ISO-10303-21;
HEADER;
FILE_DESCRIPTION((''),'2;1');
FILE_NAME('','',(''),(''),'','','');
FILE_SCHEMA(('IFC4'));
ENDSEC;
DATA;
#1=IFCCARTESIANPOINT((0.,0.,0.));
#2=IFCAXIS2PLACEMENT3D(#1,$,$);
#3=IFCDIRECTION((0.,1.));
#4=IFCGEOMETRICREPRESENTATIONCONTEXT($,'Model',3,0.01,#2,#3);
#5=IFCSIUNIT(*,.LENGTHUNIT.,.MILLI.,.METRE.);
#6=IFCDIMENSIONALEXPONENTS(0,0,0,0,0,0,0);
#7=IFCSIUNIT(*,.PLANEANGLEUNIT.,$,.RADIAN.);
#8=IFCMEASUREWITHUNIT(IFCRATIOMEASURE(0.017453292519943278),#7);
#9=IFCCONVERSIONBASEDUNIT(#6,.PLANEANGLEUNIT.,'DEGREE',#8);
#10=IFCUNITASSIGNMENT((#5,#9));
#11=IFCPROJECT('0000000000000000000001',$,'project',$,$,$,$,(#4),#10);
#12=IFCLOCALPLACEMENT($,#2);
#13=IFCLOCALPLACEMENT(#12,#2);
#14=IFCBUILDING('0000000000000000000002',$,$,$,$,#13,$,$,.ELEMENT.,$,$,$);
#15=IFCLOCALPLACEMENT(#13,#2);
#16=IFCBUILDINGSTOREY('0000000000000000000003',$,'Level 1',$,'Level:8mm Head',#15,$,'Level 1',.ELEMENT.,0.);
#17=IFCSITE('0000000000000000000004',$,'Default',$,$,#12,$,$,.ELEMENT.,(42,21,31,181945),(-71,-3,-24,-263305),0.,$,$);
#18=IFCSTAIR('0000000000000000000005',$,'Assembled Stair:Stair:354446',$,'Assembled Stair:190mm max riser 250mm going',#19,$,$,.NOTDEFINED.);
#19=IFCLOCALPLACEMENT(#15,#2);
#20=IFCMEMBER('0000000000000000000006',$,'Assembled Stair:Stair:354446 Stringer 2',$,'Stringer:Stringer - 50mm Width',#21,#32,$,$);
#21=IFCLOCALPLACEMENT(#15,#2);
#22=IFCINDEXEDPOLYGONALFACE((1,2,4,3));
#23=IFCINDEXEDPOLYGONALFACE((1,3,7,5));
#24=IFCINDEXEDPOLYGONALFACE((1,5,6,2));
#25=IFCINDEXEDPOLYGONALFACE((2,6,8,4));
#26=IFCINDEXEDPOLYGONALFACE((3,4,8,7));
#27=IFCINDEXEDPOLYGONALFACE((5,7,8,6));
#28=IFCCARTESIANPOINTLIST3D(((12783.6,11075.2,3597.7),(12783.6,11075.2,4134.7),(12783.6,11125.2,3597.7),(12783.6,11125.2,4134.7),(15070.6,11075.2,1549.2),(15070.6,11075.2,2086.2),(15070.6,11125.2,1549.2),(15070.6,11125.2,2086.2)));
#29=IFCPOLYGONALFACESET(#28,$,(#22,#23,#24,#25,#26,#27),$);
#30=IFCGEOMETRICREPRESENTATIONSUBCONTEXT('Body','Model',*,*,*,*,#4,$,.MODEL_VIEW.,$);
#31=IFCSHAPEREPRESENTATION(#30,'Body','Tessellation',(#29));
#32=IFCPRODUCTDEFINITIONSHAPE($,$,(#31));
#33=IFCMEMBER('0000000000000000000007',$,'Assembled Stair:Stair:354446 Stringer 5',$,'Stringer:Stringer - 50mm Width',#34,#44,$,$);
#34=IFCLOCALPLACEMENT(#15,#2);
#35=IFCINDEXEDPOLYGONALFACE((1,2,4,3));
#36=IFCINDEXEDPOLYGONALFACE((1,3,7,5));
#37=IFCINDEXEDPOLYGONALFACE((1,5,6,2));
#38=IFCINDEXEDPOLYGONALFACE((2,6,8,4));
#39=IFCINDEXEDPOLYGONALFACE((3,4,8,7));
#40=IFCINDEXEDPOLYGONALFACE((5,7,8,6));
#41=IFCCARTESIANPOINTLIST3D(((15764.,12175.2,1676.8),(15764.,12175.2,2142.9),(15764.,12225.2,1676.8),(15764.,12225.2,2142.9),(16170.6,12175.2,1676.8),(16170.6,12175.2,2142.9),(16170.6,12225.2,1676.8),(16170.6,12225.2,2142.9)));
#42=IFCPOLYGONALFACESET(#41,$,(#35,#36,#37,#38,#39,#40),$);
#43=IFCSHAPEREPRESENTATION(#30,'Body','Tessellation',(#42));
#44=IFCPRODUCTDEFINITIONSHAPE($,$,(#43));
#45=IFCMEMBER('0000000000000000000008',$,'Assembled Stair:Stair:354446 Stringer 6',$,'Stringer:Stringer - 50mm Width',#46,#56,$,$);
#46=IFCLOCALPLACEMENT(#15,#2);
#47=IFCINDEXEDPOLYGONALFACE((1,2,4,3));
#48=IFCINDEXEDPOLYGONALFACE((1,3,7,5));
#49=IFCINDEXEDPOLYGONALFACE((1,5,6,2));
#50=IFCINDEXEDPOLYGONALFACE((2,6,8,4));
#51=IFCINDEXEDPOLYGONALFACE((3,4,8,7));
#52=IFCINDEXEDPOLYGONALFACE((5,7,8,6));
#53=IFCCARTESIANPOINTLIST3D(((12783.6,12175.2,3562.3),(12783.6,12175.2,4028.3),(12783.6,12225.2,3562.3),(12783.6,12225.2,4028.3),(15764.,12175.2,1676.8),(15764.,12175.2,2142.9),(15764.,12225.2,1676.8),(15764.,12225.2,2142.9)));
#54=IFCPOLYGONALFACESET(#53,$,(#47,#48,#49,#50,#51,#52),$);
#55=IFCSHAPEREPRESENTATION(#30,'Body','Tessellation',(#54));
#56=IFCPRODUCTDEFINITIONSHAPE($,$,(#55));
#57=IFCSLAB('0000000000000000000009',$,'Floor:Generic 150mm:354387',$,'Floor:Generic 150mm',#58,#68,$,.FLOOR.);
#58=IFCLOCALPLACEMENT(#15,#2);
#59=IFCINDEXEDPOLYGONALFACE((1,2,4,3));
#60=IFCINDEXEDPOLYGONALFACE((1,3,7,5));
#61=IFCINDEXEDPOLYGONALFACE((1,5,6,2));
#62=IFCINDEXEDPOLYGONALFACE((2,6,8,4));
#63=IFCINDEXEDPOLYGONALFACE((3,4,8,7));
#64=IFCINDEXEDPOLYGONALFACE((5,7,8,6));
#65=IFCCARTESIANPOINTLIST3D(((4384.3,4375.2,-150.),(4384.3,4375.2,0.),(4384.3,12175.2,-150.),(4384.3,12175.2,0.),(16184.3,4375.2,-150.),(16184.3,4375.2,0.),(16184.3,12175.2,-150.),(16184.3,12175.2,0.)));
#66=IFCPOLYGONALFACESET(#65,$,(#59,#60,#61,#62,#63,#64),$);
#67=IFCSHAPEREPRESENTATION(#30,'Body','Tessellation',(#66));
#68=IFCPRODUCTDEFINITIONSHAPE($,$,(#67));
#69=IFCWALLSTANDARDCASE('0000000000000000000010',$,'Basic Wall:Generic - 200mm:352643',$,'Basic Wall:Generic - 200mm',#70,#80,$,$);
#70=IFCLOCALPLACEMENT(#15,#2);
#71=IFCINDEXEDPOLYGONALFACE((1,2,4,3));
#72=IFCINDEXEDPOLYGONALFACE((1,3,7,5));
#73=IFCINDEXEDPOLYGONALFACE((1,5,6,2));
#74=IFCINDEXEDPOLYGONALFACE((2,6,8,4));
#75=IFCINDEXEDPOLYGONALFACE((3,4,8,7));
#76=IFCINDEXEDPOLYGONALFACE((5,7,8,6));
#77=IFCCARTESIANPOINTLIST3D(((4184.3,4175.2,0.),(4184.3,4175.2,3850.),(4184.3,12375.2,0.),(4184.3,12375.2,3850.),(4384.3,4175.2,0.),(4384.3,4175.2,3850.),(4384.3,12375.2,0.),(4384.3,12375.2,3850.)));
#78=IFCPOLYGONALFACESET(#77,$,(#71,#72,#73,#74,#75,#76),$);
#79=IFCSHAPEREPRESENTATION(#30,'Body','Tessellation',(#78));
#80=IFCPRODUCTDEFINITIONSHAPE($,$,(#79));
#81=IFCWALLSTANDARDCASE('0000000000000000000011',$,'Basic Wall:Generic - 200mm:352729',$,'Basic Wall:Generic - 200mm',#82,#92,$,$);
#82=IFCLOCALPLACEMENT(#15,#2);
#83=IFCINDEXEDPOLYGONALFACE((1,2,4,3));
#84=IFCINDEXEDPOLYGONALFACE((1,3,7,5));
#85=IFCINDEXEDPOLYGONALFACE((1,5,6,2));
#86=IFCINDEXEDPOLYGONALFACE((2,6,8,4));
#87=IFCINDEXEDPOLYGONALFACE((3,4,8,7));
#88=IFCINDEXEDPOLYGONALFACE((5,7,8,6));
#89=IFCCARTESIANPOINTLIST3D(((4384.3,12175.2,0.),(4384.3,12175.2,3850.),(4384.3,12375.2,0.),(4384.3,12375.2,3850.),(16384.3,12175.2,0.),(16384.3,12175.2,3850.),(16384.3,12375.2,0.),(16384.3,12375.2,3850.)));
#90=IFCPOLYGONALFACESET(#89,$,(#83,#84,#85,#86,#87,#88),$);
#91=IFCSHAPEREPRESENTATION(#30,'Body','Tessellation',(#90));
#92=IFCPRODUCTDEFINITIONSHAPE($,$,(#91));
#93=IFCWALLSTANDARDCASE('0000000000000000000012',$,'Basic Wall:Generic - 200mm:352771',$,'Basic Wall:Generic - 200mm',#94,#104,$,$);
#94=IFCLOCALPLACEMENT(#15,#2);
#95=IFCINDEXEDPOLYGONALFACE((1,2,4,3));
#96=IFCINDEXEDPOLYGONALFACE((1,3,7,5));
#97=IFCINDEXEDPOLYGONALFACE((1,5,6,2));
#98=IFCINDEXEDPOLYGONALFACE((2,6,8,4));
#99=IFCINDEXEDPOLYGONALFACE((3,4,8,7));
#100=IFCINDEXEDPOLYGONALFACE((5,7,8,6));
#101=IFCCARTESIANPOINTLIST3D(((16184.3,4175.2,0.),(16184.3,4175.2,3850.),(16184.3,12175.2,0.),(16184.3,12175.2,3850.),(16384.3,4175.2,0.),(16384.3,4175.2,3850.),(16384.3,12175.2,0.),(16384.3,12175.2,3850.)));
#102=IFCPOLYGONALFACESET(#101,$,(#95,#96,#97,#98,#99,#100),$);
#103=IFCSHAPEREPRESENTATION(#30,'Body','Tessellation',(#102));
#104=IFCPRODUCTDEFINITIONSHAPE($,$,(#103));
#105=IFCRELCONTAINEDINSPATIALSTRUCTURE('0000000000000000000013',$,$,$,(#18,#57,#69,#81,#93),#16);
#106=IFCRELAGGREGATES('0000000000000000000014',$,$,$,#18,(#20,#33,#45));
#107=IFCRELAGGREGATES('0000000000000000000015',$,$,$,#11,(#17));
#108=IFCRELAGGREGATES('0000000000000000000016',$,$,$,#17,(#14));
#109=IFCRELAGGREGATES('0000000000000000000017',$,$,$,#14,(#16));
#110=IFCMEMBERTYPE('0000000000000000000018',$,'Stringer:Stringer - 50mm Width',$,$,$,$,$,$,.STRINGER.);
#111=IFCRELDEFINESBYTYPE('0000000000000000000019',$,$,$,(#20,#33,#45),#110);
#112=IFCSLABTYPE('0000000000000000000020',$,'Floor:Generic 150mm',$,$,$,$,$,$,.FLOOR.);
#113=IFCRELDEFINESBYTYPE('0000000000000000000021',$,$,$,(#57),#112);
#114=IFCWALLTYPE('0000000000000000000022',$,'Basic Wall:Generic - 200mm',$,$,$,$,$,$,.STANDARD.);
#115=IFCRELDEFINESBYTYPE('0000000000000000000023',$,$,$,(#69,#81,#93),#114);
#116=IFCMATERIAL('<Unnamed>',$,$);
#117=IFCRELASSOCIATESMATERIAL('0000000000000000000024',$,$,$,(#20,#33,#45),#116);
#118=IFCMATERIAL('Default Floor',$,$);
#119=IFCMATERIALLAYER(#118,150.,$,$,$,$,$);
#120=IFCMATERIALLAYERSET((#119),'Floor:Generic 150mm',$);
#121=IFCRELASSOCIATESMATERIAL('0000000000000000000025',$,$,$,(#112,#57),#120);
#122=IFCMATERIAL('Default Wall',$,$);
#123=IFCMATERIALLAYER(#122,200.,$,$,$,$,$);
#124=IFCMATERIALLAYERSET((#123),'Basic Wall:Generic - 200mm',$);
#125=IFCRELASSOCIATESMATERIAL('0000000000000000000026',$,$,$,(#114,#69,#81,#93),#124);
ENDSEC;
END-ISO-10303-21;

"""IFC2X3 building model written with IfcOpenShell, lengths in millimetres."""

from ifc_helpers import new_model, entity, si_unit, converted_unit, direction, frame, frame_2d, origin, place, context, subcontext, project, spatial, polyline, rectangle, outline, extrude, clip, bounded_halfspace, material, layer, layer_set, layer_usage, type_object, element, aggregate, save


model = new_model("IFC2X3")

# Units and contexts
model_context = context("Model", 3, precision=0.01, world=origin(), true_north=direction((0.0, 1.0)))
body_context = subcontext(model_context, "Body", "Model", "MODEL_VIEW")
ifc_project = project(units=[si_unit("LENGTHUNIT", "METRE", prefix="MILLI"), converted_unit("PLANEANGLEUNIT", "DEGREE", entity("IfcRatioMeasure", 0.017453292519943278), si_unit("PLANEANGLEUNIT", "RADIAN"), dimensions=[0, 0, 0, 0, 0, 0, 0])], contexts=[model_context])

# Site, building, storey
site_placement = place(None, origin())
site = spatial("IfcSite", under=ifc_project, at=site_placement, Name="Default", CompositionType="ELEMENT", RefLatitude=(42, 21, 31, 181945), RefLongitude=(-71, -3, -24, -263305), RefElevation=0.0)
building_placement = place(site_placement, origin())
building = spatial("IfcBuilding", under=site, at=building_placement, CompositionType="ELEMENT")
storey_placement = place(building_placement, origin())
storey = spatial("IfcBuildingStorey", under=building, at=storey_placement, Name="Level 1", ObjectType="Level:8mm Head", LongName="Level 1", CompositionType="ELEMENT", Elevation=0.0)

# Stair, members
stair_placement = place(storey_placement, origin())
stair = element("IfcStair", 1, at=stair_placement, inside=storey, Name="Assembled Stair:Stair:354446", ObjectType="Assembled Stair:190mm max riser 250mm going", ShapeType="NOTDEFINED")
ifc_material_1 = material(Name="<Unnamed>")
member_type = type_object("IfcMemberType", Name="Stringer:Stringer - 50mm Width", PredefinedType="STRINGER")
member_1_placement = place(stair_placement, origin())
member_1 = element("IfcMember", 2, at=member_1_placement, type_object=member_type, material=ifc_material_1, Name="Assembled Stair:Stair:354446 Stringer 2", ObjectType="Stringer:Stringer - 50mm Width", context=body_context, shape_type="SweptSolid", body=[
    extrude(outline(polyline([(-1714.3, -200.0), (1356.0, -200.0), (1714.3, 200.0), (-1356.0, 200.0), (-1714.3, -200.0)])), frame((13927.1, 11075.2, 2842.0), z_axis=(0.0, 1.0, 0.0), x_axis=(-0.744871, 0.0, 0.667208)), (0.0, 0.0, 1.0), 50.0),
])
member_2_placement = place(stair_placement, origin())
member_2 = element("IfcMember", 3, at=member_2_placement, type_object=member_type, material=ifc_material_1, Name="Assembled Stair:Stair:354446 Stringer 5", ObjectType="Stringer:Stringer - 50mm Width", context=body_context, shape_type="SweptSolid", body=[
    extrude(rectangle(XDim=406.6, YDim=50.0, at=frame_2d((0.0, 0.0), x_axis=(1.0, 0.0))), frame((15967.3, 12200.2, 1676.8), z_axis=(0.0, 0.0, 1.0), x_axis=(-1.0, 0.0, 0.0)), (0.0, 0.0, 1.0), 466.1),
])
member_3_placement = place(stair_placement, origin())
member_3 = element("IfcMember", 4, at=member_3_placement, type_object=member_type, material=ifc_material_1, Name="Assembled Stair:Stair:354446 Stringer 6", ObjectType="Stringer:Stringer - 50mm Width", context=body_context, shape_type="SweptSolid", body=[
    extrude(outline(polyline([(-1887.9, -196.9), (1638.7, -196.9), (1887.9, 196.9), (-1638.7, 196.9), (-1887.9, -196.9)])), frame((14273.8, 12175.2, 2852.6), z_axis=(0.0, 1.0, 0.0), x_axis=(-0.845092, 0.0, 0.53462)), (0.0, 0.0, 1.0), 50.0),
])

# Slab
ifc_material_2 = material(Name="Default Floor")
ifc_layer_1 = layer(ifc_material_2, 150.0)
ifc_layer_set_1 = layer_set([ifc_layer_1], Name="Floor:Generic 150mm")
ifc_layer_usage_1 = layer_usage(ifc_layer_set_1, "AXIS3", "POSITIVE", 0.0)
slab_type = type_object("IfcSlabType", Name="Floor:Generic 150mm", PredefinedType="FLOOR", material=ifc_layer_set_1)
slab_placement = place(storey_placement, origin())
element("IfcSlab", 5, at=slab_placement, inside=storey, type_object=slab_type, material=ifc_layer_usage_1, Name="Floor:Generic 150mm:354387", ObjectType="Floor:Generic 150mm", PredefinedType="FLOOR", context=body_context, shape_type="SweptSolid", body=[
    extrude(rectangle(XDim=7800.0, YDim=11800.0, at=frame_2d((0.0, 0.0), x_axis=(1.0, 0.0))), frame((10284.3, 8275.2, 0.0), z_axis=(0.0, 0.0, -1.0), x_axis=(0.0, 1.0, 0.0)), (0.0, 0.0, 1.0), 150.0),
])

# Walls
ifc_material_3 = material(Name="Default Wall")
ifc_layer_2 = layer(ifc_material_3, 200.0)
ifc_layer_set_2 = layer_set([ifc_layer_2], Name="Basic Wall:Generic - 200mm")
ifc_layer_usage_2 = layer_usage(ifc_layer_set_2, "AXIS2", "NEGATIVE", 100.0)
wall_type = type_object("IfcWallType", Name="Basic Wall:Generic - 200mm", PredefinedType="STANDARD", material=ifc_layer_set_2)
wall_1_placement = place(storey_placement, frame((4284.3, 4175.2, 0.0), z_axis=(0.0, 0.0, 1.0), x_axis=(0.0, 1.0, 0.0)))
element("IfcWallStandardCase", 6, at=wall_1_placement, inside=storey, type_object=wall_type, material=ifc_layer_usage_2, Name="Basic Wall:Generic - 200mm:352643", ObjectType="Basic Wall:Generic - 200mm", context=body_context, shape_type="Clipping", body=[
    clip(extrude(rectangle(XDim=8200.0, YDim=200.0, at=frame_2d((4100.0, 0.0), x_axis=(-1.0, 0.0))), origin(), (0.0, 0.0, 1.0), 3850.0), bounded_halfspace(frame((0.0, -100.0, 3850.0), z_axis=(0.0, 0.0, -1.0), x_axis=(0.0, -1.0, 0.0)), True, frame((0.0, -100.0, 3850.0)), polyline([(0.0, 0.0), (200.0, 0.0), (5200.0, 0.0), (5400.0, 0.0), (8000.0, 0.0), (8200.0, 0.0), (8200.0, 200.0), (0.0, 200.0), (0.0, 0.0)]))),
])
wall_2_placement = place(storey_placement, frame((4384.3, 12275.2, 0.0)))
element("IfcWallStandardCase", 7, at=wall_2_placement, inside=storey, type_object=wall_type, material=ifc_layer_usage_2, Name="Basic Wall:Generic - 200mm:352729", ObjectType="Basic Wall:Generic - 200mm", context=body_context, shape_type="Clipping", body=[
    clip(extrude(rectangle(XDim=12000.0, YDim=200.0, at=frame_2d((6000.0, 0.0), x_axis=(-1.0, 0.0))), origin(), (0.0, 0.0, 1.0), 3850.0), bounded_halfspace(frame((0.0, -100.0, 3850.0), z_axis=(0.0, 0.0, -1.0), x_axis=(1.0, 0.0, 0.0)), True, frame((0.0, -100.0, 3850.0)), polyline([(0.0, 0.0), (3800.0, 0.0), (4000.0, 0.0), (8200.0, 0.0), (8400.0, 0.0), (11800.0, 0.0), (12000.0, 0.0), (12000.0, 200.0), (0.0, 200.0), (0.0, 0.0)]))),
])
wall_3_placement = place(storey_placement, frame((16284.3, 12175.2, 0.0), z_axis=(0.0, 0.0, 1.0), x_axis=(0.0, -1.0, 0.0)))
element("IfcWallStandardCase", 8, at=wall_3_placement, inside=storey, type_object=wall_type, material=ifc_layer_usage_2, Name="Basic Wall:Generic - 200mm:352771", ObjectType="Basic Wall:Generic - 200mm", context=body_context, shape_type="Clipping", body=[
    clip(extrude(rectangle(XDim=8000.0, YDim=200.0, at=frame_2d((4000.0, 0.0), x_axis=(-1.0, 0.0))), origin(), (0.0, 0.0, 1.0), 3850.0), bounded_halfspace(frame((0.0, -100.0, 3850.0), z_axis=(0.0, 0.0, -1.0), x_axis=(0.0, 1.0, 0.0)), True, frame((0.0, -100.0, 3850.0)), polyline([(0.0, 0.0), (2700.0, 0.0), (4300.0, 0.0), (4500.0, 0.0), (7800.0, 0.0), (8000.0, 0.0), (8000.0, 200.0), (0.0, 200.0), (0.0, 0.0)]))),
])

aggregate(stair, [member_1, member_2, member_3])

save(model, "model.ifc")
